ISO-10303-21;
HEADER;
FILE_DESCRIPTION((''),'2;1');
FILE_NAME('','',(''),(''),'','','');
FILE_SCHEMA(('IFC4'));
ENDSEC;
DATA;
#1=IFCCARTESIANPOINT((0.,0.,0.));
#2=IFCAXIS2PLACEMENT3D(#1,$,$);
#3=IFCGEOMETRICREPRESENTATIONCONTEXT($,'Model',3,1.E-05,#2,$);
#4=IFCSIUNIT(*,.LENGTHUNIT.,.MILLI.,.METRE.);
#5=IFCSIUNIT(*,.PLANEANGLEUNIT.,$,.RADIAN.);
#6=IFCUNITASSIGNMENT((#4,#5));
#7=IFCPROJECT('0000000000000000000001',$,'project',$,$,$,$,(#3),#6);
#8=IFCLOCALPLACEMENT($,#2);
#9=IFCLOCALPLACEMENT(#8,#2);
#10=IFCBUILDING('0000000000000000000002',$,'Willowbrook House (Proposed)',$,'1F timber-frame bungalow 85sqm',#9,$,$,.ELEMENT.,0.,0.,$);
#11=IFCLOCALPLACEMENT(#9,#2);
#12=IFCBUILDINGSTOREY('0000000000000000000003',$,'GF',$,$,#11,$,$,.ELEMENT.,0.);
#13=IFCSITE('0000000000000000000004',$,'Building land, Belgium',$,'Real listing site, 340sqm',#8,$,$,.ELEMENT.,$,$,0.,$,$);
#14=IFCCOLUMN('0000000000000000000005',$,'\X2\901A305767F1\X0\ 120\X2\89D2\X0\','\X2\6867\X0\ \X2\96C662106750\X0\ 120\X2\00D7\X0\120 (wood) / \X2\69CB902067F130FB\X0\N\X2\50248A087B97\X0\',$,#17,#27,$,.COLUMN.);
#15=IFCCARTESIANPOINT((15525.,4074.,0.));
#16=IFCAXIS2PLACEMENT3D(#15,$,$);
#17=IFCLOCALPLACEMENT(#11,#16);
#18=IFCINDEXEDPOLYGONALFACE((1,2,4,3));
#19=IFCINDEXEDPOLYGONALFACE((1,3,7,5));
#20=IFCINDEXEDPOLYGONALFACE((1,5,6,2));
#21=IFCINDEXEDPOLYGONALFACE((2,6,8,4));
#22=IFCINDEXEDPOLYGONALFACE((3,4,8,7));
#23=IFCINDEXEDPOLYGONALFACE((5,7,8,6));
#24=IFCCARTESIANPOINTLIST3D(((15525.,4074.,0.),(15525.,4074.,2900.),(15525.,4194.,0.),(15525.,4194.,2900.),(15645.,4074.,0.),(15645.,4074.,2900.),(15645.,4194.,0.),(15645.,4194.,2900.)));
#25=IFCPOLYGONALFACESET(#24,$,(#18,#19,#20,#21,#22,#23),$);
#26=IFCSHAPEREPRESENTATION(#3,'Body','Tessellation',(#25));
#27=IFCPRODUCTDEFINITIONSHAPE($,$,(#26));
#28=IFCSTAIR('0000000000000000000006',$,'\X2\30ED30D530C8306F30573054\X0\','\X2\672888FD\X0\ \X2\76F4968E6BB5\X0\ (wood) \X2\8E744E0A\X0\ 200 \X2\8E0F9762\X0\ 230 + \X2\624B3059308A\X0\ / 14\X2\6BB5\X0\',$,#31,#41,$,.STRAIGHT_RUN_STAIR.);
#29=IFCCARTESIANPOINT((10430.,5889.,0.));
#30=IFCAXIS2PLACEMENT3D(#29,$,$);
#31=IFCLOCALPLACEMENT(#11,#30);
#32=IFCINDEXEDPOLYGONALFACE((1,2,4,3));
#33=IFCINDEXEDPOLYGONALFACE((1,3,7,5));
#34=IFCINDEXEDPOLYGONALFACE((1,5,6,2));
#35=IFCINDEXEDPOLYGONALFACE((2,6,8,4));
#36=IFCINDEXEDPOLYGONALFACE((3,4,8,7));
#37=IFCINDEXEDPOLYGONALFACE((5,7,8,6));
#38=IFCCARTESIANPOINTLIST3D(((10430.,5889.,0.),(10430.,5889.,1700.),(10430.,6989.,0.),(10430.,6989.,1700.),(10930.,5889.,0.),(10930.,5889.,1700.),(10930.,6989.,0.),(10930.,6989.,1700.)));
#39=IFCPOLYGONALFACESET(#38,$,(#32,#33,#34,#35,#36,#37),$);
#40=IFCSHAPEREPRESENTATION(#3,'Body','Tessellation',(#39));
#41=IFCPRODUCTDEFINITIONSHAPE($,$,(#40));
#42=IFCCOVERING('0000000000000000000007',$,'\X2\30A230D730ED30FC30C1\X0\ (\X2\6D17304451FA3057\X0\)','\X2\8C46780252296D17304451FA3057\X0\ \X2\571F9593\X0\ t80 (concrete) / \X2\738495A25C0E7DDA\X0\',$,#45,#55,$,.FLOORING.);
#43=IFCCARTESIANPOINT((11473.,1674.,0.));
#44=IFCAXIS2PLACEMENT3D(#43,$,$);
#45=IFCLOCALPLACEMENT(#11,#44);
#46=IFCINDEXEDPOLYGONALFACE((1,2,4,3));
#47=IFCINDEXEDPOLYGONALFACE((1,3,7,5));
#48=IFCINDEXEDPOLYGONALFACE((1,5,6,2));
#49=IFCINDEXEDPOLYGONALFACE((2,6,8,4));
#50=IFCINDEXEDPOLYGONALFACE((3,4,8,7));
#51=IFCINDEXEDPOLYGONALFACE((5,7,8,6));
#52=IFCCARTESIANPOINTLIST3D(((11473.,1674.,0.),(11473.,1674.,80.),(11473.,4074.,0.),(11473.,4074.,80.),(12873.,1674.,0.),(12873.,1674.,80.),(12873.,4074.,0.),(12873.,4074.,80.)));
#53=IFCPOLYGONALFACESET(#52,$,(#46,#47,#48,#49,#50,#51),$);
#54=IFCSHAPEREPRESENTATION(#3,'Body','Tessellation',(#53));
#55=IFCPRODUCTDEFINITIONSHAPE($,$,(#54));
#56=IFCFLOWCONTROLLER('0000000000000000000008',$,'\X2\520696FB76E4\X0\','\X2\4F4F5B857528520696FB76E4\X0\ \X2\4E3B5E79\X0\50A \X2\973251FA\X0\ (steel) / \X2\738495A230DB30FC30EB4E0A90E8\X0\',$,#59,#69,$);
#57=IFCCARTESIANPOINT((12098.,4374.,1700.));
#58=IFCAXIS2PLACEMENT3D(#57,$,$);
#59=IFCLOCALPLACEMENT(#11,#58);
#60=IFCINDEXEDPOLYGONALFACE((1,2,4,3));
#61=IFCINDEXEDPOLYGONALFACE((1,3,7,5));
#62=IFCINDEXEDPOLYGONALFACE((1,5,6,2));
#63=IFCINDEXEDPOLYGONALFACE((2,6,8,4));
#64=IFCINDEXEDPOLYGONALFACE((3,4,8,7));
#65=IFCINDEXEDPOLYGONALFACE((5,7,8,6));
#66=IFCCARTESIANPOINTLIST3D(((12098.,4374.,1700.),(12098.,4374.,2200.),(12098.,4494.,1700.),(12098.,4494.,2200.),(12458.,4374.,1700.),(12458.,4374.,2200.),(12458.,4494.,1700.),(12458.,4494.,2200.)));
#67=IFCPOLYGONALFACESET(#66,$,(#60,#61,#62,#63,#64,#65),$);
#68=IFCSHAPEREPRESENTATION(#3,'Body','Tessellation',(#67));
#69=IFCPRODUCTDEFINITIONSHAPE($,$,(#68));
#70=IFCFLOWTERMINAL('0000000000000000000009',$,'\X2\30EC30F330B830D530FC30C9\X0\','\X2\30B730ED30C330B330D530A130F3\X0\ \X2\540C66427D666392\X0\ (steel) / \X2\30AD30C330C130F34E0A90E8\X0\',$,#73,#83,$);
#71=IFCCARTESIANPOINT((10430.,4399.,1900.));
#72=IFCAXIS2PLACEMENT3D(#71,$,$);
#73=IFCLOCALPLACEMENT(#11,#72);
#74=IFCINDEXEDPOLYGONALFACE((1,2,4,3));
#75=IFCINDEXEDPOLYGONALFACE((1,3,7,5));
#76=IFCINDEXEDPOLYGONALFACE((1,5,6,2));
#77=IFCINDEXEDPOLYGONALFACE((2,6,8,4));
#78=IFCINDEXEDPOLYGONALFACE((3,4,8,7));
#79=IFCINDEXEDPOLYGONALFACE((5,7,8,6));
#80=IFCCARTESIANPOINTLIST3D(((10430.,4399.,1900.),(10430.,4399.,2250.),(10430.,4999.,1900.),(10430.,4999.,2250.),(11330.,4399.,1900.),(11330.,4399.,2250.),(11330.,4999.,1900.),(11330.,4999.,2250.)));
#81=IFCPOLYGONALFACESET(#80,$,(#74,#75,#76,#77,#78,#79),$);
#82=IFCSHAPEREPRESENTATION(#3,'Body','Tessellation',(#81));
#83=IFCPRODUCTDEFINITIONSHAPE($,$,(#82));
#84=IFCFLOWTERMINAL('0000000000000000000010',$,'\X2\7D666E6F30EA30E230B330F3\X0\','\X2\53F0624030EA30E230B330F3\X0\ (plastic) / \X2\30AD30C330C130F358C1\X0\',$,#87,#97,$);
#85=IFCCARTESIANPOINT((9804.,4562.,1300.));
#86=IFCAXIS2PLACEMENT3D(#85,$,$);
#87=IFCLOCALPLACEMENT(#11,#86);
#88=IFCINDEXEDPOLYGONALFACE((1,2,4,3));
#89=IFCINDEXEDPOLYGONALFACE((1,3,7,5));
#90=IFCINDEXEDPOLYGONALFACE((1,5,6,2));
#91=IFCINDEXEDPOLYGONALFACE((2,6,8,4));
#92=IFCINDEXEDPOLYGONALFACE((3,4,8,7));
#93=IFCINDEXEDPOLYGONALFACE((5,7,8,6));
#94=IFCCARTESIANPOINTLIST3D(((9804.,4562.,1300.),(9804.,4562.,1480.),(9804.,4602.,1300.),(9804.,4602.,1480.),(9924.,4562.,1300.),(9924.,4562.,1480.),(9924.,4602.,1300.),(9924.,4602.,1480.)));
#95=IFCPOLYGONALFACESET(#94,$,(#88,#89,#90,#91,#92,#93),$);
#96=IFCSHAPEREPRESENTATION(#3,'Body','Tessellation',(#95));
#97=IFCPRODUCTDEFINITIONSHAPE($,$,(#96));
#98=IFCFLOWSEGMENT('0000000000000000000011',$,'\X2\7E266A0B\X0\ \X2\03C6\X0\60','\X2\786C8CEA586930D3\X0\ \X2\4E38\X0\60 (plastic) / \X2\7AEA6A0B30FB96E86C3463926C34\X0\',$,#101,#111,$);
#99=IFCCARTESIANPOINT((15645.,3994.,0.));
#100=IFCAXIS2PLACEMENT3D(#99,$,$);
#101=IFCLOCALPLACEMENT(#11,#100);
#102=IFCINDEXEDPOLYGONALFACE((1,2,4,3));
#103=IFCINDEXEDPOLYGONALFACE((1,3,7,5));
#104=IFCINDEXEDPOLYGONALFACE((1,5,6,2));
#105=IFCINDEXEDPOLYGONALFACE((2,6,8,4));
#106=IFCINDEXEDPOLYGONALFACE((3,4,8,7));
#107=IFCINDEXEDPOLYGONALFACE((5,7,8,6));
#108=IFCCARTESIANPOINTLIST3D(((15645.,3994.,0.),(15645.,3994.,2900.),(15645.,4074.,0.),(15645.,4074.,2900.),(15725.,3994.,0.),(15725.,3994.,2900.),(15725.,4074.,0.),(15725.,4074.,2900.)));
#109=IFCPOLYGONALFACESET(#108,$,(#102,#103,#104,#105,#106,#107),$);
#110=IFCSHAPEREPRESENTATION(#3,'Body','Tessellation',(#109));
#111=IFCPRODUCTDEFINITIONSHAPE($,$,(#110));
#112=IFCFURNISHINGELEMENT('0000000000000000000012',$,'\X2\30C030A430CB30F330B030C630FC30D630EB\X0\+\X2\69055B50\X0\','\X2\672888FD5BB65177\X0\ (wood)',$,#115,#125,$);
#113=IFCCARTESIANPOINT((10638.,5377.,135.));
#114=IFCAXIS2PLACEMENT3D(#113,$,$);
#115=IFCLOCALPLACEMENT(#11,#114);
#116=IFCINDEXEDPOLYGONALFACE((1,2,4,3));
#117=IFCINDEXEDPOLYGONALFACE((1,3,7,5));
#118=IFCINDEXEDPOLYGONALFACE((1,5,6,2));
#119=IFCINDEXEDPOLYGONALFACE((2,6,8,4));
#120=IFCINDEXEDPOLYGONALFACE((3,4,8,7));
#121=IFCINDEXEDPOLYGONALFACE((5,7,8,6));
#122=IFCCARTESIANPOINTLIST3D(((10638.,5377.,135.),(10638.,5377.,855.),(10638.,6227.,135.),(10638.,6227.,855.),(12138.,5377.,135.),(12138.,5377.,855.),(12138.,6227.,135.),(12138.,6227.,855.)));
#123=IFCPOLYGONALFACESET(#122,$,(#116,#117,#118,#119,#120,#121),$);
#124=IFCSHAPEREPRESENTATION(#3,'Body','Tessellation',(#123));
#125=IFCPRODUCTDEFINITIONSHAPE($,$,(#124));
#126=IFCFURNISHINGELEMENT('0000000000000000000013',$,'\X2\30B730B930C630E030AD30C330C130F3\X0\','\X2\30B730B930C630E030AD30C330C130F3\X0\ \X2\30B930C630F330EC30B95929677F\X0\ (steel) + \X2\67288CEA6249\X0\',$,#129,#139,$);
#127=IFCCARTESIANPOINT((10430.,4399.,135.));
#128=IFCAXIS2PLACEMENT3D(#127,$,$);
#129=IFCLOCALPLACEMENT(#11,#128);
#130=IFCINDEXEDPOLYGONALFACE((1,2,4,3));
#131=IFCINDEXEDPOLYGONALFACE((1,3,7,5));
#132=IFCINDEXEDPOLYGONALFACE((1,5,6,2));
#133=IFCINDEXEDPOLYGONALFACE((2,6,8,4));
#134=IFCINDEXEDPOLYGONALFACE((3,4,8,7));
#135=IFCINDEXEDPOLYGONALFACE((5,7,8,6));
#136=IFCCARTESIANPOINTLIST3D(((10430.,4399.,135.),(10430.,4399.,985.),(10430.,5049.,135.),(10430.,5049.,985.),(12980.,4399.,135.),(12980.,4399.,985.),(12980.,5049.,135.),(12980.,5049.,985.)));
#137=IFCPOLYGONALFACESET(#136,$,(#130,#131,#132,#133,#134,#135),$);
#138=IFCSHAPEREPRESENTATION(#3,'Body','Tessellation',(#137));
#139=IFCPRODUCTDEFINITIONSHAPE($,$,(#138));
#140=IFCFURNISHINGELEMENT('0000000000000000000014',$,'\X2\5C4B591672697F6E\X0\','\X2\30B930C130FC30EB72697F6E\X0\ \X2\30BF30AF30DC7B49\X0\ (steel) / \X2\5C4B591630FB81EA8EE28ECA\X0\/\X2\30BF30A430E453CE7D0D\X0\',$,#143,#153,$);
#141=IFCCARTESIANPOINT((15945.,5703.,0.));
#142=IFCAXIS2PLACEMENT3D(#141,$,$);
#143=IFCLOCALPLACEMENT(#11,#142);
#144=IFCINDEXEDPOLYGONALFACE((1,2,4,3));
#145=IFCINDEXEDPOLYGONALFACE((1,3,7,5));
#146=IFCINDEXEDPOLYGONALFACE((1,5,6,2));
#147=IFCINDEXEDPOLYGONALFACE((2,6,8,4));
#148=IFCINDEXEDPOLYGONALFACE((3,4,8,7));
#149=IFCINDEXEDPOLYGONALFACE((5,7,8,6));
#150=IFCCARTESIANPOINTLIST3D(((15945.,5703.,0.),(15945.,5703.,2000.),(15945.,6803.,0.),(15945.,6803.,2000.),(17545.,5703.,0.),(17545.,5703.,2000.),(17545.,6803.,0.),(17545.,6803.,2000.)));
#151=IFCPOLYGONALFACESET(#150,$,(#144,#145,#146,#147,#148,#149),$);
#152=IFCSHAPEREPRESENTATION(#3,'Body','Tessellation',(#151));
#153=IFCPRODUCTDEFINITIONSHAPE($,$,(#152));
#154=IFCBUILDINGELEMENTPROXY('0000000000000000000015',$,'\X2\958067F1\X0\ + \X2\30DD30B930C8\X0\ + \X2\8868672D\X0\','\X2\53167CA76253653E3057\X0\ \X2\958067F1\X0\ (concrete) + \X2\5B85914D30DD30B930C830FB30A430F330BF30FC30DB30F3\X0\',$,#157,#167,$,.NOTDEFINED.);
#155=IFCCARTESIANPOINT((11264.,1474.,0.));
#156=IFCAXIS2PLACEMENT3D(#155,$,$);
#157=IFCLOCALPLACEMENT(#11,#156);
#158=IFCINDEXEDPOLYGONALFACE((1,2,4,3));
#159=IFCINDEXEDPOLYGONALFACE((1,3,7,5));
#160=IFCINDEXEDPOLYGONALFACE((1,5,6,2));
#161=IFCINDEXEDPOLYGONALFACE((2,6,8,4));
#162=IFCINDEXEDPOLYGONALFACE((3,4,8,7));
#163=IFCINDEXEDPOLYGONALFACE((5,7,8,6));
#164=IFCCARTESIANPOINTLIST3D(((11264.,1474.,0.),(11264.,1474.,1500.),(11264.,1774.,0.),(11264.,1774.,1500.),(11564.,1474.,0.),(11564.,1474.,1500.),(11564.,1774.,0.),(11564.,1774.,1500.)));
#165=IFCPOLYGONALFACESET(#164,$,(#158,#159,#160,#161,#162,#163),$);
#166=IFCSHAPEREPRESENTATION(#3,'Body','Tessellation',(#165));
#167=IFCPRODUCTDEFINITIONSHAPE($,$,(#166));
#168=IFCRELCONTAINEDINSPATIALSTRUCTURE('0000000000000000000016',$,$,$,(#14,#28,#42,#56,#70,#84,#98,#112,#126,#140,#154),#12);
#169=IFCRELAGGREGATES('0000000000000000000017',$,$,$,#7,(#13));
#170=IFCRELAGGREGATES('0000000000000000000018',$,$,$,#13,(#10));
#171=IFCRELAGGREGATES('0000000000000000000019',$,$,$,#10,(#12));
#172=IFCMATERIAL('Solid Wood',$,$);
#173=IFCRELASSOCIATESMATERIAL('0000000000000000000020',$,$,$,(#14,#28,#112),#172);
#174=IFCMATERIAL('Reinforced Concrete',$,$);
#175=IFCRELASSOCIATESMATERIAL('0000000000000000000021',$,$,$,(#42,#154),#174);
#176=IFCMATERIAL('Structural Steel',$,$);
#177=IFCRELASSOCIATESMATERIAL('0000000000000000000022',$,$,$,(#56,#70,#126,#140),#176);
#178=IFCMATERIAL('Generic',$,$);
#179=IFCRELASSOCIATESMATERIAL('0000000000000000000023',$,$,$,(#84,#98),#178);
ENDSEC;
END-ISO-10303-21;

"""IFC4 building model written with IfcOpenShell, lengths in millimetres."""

from ifc_helpers import new_model, si_unit, frame, frame_2d, origin, place, context, project, spatial, rectangle, extrude, material, element, save


model = new_model("IFC4")

# Units and contexts
model_context = context("Model", 3, precision=1e-05, world=origin())
ifc_project = project(units=[si_unit("LENGTHUNIT", "METRE", prefix="MILLI"), si_unit("PLANEANGLEUNIT", "RADIAN")], contexts=[model_context])

# Site, building, storey
site_placement = place(None, origin())
site = spatial("IfcSite", under=ifc_project, at=site_placement, Name="Building land, Belgium", ObjectType="Real listing site, 340sqm", CompositionType="ELEMENT", RefElevation=0.0)
building_placement = place(site_placement, origin())
building = spatial("IfcBuilding", under=site, at=building_placement, Name="Willowbrook House (Proposed)", ObjectType="1F timber-frame bungalow 85sqm", CompositionType="ELEMENT", ElevationOfRefHeight=0.0, ElevationOfTerrain=0.0)
storey_placement = place(building_placement, origin())
storey = spatial("IfcBuildingStorey", under=building, at=storey_placement, Name="GF", CompositionType="ELEMENT", Elevation=0.0)

# Column
ifc_material_1 = material(Name="Solid Wood")
column_1_placement = place(storey_placement, frame((15525.0, 4074.0, 0.0)))
element("IfcColumn", 1, at=column_1_placement, inside=storey, material=ifc_material_1, Name="通し柱 120角", Description="桧 集成材 120×120 (wood) / 構造柱・N値計算", PredefinedType="COLUMN", context=model_context, shape_type="SweptSolid", body=[
    extrude(rectangle(XDim=120.0, YDim=120.0, at=frame_2d((60.0, 60.0))), frame((15525.0, 4074.0, 0.0)), (0.0, 0.0, 1.0), 2900.0),
])

# Stair
stair_placement = place(storey_placement, frame((10430.0, 5889.0, 0.0)))
element("IfcStair", 2, at=stair_placement, inside=storey, material=ifc_material_1, Name="ロフトはしご", Description="木製 直階段 (wood) 蹴上 200 踏面 230 + 手すり / 14段", PredefinedType="STRAIGHT_RUN_STAIR", context=model_context, shape_type="SweptSolid", body=[
    extrude(rectangle(XDim=500.0, YDim=1100.0, at=frame_2d((250.0, 550.0))), frame((10430.0, 5889.0, 0.0)), (0.0, 0.0, 1.0), 1700.0),
])

# Covering
ifc_material_2 = material(Name="Reinforced Concrete")
covering_placement = place(storey_placement, frame((11473.0, 1674.0, 0.0)))
element("IfcCovering", 3, at=covering_placement, inside=storey, material=ifc_material_2, Name="アプローチ (洗い出し)", Description="豆砂利洗い出し 土間 t80 (concrete) / 玄関導線", PredefinedType="FLOORING", context=model_context, shape_type="SweptSolid", body=[
    extrude(rectangle(XDim=1400.0, YDim=2400.0, at=frame_2d((700.0, 1200.0))), frame((11473.0, 1674.0, 0.0)), (0.0, 0.0, 1.0), 80.0),
])

# Flow controller
ifc_material_3 = material(Name="Structural Steel")
flow_controller_placement = place(storey_placement, frame((12098.0, 4374.0, 1700.0)))
element("IfcFlowController", 4, at=flow_controller_placement, inside=storey, material=ifc_material_3, Name="分電盤", Description="住宅用分電盤 主幹50A 露出 (steel) / 玄関ホール上部", context=model_context, shape_type="SweptSolid", body=[
    extrude(rectangle(XDim=360.0, YDim=120.0, at=frame_2d((180.0, 60.0))), frame((12098.0, 4374.0, 1700.0)), (0.0, 0.0, 1.0), 500.0),
])

# Flow terminals
flow_terminal_1_placement = place(storey_placement, frame((10430.0, 4399.0, 1900.0)))
element("IfcFlowTerminal", 5, at=flow_terminal_1_placement, inside=storey, material=ifc_material_3, Name="レンジフード", Description="シロッコファン 同時給排 (steel) / キッチン上部", context=model_context, shape_type="SweptSolid", body=[
    extrude(rectangle(XDim=900.0, YDim=600.0, at=frame_2d((450.0, 300.0))), frame((10430.0, 4399.0, 1900.0)), (0.0, 0.0, 1.0), 350.0),
])
ifc_material_4 = material(Name="Generic")
flow_terminal_2_placement = place(storey_placement, frame((9804.0, 4562.0, 1300.0)))
element("IfcFlowTerminal", 6, at=flow_terminal_2_placement, inside=storey, material=ifc_material_4, Name="給湯リモコン", Description="台所リモコン (plastic) / キッチン壁", context=model_context, shape_type="SweptSolid", body=[
    extrude(rectangle(XDim=120.0, YDim=40.0, at=frame_2d((60.0, 20.0))), frame((9804.0, 4562.0, 1300.0)), (0.0, 0.0, 1.0), 180.0),
])

# Flow segment
flow_segment_placement = place(storey_placement, frame((15645.0, 3994.0, 0.0)))
element("IfcFlowSegment", 7, at=flow_segment_placement, inside=storey, material=ifc_material_4, Name="縦樋 φ60", Description="硬質塩ビ 丸60 (plastic) / 竪樋・雨水排水", context=model_context, shape_type="SweptSolid", body=[
    extrude(rectangle(XDim=80.0, YDim=80.0, at=frame_2d((40.0, 40.0))), frame((15645.0, 3994.0, 0.0)), (0.0, 0.0, 1.0), 2900.0),
])

# Furnishing elements
furnishing_1_placement = place(storey_placement, frame((10638.0, 5377.0, 135.0)))
element("IfcFurnishingElement", 8, at=furnishing_1_placement, inside=storey, material=ifc_material_1, Name="ダイニングテーブル+椅子", Description="木製家具 (wood)", context=model_context, shape_type="SweptSolid", body=[
    extrude(rectangle(XDim=1500.0, YDim=850.0, at=frame_2d((750.0, 425.0))), frame((10638.0, 5377.0, 135.0)), (0.0, 0.0, 1.0), 720.0),
])
furnishing_2_placement = place(storey_placement, frame((10430.0, 4399.0, 135.0)))
element("IfcFurnishingElement", 9, at=furnishing_2_placement, inside=storey, material=ifc_material_3, Name="システムキッチン", Description="システムキッチン ステンレス天板 (steel) + 木質扉", context=model_context, shape_type="SweptSolid", body=[
    extrude(rectangle(XDim=2550.0, YDim=650.0, at=frame_2d((1275.0, 325.0))), frame((10430.0, 4399.0, 135.0)), (0.0, 0.0, 1.0), 850.0),
])
furnishing_3_placement = place(storey_placement, frame((15945.0, 5703.0, 0.0)))
element("IfcFurnishingElement", 10, at=furnishing_3_placement, inside=storey, material=ifc_material_3, Name="屋外物置", Description="スチール物置 タクボ等 (steel) / 屋外・自転車/タイヤ収納", context=model_context, shape_type="SweptSolid", body=[
    extrude(rectangle(XDim=1600.0, YDim=1100.0, at=frame_2d((800.0, 550.0))), frame((15945.0, 5703.0, 0.0)), (0.0, 0.0, 1.0), 2000.0),
])

# Building element proxy
proxy_placement = place(storey_placement, frame((11264.0, 1474.0, 0.0)))
element("IfcBuildingElementProxy", 11, at=proxy_placement, inside=storey, material=ifc_material_2, Name="門柱 + ポスト + 表札", Description="化粧打放し 門柱 (concrete) + 宅配ポスト・インターホン", PredefinedType="NOTDEFINED", context=model_context, shape_type="SweptSolid", body=[
    extrude(rectangle(XDim=300.0, YDim=300.0, at=frame_2d((150.0, 150.0))), frame((11264.0, 1474.0, 0.0)), (0.0, 0.0, 1.0), 1500.0),
])

save(model, "model.ifc")
